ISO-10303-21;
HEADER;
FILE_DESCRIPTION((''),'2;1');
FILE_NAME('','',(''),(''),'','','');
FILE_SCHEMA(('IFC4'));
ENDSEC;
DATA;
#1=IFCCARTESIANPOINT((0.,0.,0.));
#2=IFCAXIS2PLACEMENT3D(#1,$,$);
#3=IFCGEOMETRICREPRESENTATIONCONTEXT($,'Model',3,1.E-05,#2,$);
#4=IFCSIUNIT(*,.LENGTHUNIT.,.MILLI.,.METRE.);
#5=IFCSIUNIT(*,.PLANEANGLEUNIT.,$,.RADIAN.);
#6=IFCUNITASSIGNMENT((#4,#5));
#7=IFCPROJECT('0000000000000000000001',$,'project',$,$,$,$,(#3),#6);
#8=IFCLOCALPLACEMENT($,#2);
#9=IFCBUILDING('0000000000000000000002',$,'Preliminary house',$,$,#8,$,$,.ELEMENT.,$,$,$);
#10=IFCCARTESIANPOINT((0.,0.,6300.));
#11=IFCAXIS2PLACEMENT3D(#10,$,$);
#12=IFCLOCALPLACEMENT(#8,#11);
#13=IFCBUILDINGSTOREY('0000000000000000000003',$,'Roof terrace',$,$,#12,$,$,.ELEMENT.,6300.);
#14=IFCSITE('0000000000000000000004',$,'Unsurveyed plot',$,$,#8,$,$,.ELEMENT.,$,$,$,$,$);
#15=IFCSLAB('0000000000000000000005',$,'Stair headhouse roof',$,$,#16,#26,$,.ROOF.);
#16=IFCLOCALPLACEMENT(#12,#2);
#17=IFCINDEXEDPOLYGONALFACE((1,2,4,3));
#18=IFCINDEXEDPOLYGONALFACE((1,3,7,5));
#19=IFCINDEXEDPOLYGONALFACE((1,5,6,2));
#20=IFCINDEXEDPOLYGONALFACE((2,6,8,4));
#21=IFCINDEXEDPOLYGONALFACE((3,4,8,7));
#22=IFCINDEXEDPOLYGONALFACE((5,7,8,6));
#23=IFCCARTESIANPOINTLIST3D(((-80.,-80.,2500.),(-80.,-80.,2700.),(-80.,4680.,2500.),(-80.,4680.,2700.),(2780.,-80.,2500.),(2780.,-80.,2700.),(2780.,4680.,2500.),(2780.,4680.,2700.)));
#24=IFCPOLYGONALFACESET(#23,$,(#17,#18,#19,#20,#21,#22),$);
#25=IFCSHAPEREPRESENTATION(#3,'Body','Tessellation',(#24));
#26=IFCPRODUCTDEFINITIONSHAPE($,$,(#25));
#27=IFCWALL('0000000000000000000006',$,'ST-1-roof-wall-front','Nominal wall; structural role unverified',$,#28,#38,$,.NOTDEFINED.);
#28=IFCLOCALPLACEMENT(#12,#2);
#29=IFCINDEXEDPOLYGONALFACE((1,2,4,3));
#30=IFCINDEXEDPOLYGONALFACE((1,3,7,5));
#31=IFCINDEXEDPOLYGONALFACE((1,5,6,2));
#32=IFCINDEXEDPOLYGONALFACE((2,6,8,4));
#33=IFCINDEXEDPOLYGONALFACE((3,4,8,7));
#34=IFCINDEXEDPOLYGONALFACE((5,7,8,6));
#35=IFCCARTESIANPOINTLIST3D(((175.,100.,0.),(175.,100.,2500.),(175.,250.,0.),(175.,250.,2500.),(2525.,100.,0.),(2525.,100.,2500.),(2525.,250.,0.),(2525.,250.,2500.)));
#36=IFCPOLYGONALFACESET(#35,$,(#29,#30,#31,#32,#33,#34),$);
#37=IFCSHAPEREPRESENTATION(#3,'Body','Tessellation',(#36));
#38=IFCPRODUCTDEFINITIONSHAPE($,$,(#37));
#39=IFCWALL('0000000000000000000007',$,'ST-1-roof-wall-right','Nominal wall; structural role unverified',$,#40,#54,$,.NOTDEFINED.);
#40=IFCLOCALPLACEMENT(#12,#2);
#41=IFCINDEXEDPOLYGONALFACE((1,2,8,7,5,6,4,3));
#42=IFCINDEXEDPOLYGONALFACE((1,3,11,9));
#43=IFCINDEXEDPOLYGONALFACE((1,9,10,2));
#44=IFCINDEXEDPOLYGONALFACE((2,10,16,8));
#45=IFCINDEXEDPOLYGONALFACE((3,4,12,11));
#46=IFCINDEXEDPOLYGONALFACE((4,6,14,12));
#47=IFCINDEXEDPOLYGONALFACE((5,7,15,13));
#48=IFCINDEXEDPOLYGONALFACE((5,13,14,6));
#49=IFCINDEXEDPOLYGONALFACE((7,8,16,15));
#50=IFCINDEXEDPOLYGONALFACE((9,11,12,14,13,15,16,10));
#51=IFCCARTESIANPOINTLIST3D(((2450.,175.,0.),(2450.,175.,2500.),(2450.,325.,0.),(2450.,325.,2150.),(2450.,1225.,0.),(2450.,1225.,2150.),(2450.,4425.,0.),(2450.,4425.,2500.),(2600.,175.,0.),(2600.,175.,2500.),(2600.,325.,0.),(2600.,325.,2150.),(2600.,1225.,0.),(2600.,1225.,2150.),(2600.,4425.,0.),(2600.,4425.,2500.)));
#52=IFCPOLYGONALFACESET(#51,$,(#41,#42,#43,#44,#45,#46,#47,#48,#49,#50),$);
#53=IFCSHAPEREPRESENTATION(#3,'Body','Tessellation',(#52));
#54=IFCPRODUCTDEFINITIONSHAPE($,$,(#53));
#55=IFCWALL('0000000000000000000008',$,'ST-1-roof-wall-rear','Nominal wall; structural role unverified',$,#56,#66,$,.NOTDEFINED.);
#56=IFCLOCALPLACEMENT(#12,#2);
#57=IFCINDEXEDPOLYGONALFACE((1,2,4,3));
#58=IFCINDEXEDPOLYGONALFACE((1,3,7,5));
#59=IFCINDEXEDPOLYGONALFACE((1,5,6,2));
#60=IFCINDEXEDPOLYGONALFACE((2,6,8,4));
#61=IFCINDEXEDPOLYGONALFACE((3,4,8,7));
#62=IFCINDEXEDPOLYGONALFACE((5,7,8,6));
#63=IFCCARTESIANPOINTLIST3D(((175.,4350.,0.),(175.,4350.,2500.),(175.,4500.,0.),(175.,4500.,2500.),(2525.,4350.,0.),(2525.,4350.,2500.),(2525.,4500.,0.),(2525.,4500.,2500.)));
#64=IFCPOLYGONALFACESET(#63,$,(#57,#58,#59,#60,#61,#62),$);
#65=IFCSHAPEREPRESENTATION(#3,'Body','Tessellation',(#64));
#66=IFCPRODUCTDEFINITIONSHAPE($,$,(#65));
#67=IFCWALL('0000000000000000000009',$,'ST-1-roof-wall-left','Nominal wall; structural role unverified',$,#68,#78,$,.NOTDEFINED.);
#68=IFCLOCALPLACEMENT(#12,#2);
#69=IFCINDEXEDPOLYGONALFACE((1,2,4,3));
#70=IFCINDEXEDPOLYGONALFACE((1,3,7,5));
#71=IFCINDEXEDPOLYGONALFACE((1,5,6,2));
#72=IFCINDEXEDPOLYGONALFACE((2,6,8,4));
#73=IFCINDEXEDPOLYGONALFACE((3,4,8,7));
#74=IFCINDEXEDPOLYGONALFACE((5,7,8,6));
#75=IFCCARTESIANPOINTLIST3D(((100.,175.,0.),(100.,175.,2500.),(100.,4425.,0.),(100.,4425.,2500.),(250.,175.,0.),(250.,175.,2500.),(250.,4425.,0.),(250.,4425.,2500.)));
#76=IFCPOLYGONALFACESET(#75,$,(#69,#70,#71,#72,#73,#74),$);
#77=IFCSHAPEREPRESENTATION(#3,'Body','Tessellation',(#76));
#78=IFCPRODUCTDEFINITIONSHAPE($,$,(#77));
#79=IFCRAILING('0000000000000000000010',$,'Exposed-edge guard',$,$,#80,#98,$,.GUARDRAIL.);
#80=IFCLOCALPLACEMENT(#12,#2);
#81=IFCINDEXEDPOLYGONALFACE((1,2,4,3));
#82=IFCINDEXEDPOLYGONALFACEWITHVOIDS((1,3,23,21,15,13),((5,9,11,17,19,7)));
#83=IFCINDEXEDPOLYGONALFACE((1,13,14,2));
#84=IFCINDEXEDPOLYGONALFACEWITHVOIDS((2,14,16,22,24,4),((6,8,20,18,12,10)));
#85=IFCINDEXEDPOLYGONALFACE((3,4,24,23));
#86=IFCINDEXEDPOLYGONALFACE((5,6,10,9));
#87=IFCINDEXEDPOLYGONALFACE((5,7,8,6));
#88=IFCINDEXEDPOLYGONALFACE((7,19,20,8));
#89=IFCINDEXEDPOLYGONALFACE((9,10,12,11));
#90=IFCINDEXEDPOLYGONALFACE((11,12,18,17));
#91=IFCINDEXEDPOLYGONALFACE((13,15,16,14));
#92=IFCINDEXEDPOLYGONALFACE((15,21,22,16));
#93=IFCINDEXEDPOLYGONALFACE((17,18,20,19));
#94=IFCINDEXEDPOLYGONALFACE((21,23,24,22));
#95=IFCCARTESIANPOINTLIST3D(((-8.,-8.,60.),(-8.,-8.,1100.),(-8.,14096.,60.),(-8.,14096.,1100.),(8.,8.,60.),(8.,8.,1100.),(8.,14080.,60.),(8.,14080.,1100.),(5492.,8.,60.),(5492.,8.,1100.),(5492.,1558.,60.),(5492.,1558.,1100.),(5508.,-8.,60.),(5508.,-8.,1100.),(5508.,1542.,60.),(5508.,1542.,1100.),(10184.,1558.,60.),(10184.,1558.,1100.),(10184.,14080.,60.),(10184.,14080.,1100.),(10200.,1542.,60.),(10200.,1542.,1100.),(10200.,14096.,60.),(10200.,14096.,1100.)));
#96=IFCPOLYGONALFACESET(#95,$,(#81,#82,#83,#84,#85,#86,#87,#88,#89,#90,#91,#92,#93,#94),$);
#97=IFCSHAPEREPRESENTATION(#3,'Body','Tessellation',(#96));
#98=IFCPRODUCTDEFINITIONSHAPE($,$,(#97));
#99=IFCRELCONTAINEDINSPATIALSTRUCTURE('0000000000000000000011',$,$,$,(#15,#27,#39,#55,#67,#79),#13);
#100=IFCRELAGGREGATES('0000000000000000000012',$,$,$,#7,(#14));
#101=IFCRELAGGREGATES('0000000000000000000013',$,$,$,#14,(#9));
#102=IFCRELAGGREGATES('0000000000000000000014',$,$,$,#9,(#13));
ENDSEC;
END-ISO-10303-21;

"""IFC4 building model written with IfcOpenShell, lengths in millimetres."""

from ifc_helpers import new_model, si_unit, frame, origin, place, context, project, spatial, polyline, outline, extrude, element, save


model = new_model("IFC4")

# Units and contexts
model_context = context("Model", 3, precision=1e-05, world=origin())
ifc_project = project(units=[si_unit("LENGTHUNIT", "METRE", prefix="MILLI"), si_unit("PLANEANGLEUNIT", "RADIAN")], contexts=[model_context])

# Site, building, storey
placement_1 = place(None, origin())
site = spatial("IfcSite", under=ifc_project, at=placement_1, Name="Unsurveyed plot", CompositionType="ELEMENT")
building = spatial("IfcBuilding", under=site, at=placement_1, Name="Preliminary house", CompositionType="ELEMENT")
placement_2 = place(placement_1, frame((0.0, 0.0, 6300.0)))
storey = spatial("IfcBuildingStorey", under=building, at=placement_2, Name="Roof terrace", CompositionType="ELEMENT", Elevation=6300.0)

# Slab
element("IfcSlab", 1, at=placement_2, inside=storey, Name="Stair headhouse roof", PredefinedType="ROOF", context=model_context, shape_type="SweptSolid", body=[
    extrude(outline(polyline([(2780.0, -80.0), (-80.0, -80.0), (-80.0, 4680.0), (2780.0, 4680.0), (2780.0, -80.0)])), frame((0.0, 0.0, 2500.0)), (0.0, 0.0, 1.0), 200.0),
])

# Wall
element("IfcWall", 2, at=placement_2, inside=storey, Name="ST-1-roof-wall-front", Description="Nominal wall; structural role unverified", PredefinedType="NOTDEFINED", context=model_context, shape_type="SweptSolid", body=[
    extrude(outline(polyline([(2525.0, 250.0), (2525.0, 100.0), (175.0, 100.0), (175.0, 250.0), (2525.0, 250.0)])), origin(), (0.0, 0.0, 1.0), 2500.0),
])

# Wall, opening
wall_1 = element("IfcWall", 3, at=placement_2, inside=storey, Name="ST-1-roof-wall-right", Description="Nominal wall; structural role unverified", PredefinedType="NOTDEFINED", context=model_context, shape_type="SweptSolid", body=[
    extrude(outline(polyline([(2450.0, 4425.0), (2600.0, 4425.0), (2600.0, 175.0), (2450.0, 175.0), (2450.0, 4425.0)])), origin(), (0.0, 0.0, 1.0), 2500.0),
])
element("IfcOpeningElement", 4, at=placement_2, cuts=wall_1, PredefinedType="OPENING", context=model_context, shape_type="SweptSolid", body=[
    extrude(outline(polyline([(2975.0, 325.0), (2975.0, 1225.0), (2075.0, 1225.0), (2075.0, 325.0), (2975.0, 325.0)])), origin(), (0.0, 0.0, 1.0), 2150.0),
])

# Walls
element("IfcWall", 5, at=placement_2, inside=storey, Name="ST-1-roof-wall-rear", Description="Nominal wall; structural role unverified", PredefinedType="NOTDEFINED", context=model_context, shape_type="SweptSolid", body=[
    extrude(outline(polyline([(2525.0, 4500.0), (2525.0, 4350.0), (175.0, 4350.0), (175.0, 4500.0), (2525.0, 4500.0)])), origin(), (0.0, 0.0, 1.0), 2500.0),
])
element("IfcWall", 6, at=placement_2, inside=storey, Name="ST-1-roof-wall-left", Description="Nominal wall; structural role unverified", PredefinedType="NOTDEFINED", context=model_context, shape_type="SweptSolid", body=[
    extrude(outline(polyline([(100.0, 4425.0), (250.0, 4425.0), (250.0, 175.0), (100.0, 175.0), (100.0, 4425.0)])), origin(), (0.0, 0.0, 1.0), 2500.0),
])

# Railing
element("IfcRailing", 7, at=placement_2, inside=storey, Name="Exposed-edge guard", PredefinedType="GUARDRAIL", context=model_context, shape_type="SweptSolid", body=[
    extrude(outline(polyline([(-8.0, -8.0), (-8.0, 14096.0), (10200.0, 14096.0), (10200.0, 1542.0), (5508.0, 1542.0), (5508.0, -8.0), (-8.0, -8.0)]), holes=[polyline([(8.0, 8.0), (5492.0, 8.0), (5492.0, 1558.0), (10184.0, 1558.0), (10184.0, 14080.0), (8.0, 14080.0), (8.0, 8.0)])]), frame((0.0, 0.0, 60.0)), (0.0, 0.0, 1.0), 1040.0),
])

save(model, "model.ifc")
